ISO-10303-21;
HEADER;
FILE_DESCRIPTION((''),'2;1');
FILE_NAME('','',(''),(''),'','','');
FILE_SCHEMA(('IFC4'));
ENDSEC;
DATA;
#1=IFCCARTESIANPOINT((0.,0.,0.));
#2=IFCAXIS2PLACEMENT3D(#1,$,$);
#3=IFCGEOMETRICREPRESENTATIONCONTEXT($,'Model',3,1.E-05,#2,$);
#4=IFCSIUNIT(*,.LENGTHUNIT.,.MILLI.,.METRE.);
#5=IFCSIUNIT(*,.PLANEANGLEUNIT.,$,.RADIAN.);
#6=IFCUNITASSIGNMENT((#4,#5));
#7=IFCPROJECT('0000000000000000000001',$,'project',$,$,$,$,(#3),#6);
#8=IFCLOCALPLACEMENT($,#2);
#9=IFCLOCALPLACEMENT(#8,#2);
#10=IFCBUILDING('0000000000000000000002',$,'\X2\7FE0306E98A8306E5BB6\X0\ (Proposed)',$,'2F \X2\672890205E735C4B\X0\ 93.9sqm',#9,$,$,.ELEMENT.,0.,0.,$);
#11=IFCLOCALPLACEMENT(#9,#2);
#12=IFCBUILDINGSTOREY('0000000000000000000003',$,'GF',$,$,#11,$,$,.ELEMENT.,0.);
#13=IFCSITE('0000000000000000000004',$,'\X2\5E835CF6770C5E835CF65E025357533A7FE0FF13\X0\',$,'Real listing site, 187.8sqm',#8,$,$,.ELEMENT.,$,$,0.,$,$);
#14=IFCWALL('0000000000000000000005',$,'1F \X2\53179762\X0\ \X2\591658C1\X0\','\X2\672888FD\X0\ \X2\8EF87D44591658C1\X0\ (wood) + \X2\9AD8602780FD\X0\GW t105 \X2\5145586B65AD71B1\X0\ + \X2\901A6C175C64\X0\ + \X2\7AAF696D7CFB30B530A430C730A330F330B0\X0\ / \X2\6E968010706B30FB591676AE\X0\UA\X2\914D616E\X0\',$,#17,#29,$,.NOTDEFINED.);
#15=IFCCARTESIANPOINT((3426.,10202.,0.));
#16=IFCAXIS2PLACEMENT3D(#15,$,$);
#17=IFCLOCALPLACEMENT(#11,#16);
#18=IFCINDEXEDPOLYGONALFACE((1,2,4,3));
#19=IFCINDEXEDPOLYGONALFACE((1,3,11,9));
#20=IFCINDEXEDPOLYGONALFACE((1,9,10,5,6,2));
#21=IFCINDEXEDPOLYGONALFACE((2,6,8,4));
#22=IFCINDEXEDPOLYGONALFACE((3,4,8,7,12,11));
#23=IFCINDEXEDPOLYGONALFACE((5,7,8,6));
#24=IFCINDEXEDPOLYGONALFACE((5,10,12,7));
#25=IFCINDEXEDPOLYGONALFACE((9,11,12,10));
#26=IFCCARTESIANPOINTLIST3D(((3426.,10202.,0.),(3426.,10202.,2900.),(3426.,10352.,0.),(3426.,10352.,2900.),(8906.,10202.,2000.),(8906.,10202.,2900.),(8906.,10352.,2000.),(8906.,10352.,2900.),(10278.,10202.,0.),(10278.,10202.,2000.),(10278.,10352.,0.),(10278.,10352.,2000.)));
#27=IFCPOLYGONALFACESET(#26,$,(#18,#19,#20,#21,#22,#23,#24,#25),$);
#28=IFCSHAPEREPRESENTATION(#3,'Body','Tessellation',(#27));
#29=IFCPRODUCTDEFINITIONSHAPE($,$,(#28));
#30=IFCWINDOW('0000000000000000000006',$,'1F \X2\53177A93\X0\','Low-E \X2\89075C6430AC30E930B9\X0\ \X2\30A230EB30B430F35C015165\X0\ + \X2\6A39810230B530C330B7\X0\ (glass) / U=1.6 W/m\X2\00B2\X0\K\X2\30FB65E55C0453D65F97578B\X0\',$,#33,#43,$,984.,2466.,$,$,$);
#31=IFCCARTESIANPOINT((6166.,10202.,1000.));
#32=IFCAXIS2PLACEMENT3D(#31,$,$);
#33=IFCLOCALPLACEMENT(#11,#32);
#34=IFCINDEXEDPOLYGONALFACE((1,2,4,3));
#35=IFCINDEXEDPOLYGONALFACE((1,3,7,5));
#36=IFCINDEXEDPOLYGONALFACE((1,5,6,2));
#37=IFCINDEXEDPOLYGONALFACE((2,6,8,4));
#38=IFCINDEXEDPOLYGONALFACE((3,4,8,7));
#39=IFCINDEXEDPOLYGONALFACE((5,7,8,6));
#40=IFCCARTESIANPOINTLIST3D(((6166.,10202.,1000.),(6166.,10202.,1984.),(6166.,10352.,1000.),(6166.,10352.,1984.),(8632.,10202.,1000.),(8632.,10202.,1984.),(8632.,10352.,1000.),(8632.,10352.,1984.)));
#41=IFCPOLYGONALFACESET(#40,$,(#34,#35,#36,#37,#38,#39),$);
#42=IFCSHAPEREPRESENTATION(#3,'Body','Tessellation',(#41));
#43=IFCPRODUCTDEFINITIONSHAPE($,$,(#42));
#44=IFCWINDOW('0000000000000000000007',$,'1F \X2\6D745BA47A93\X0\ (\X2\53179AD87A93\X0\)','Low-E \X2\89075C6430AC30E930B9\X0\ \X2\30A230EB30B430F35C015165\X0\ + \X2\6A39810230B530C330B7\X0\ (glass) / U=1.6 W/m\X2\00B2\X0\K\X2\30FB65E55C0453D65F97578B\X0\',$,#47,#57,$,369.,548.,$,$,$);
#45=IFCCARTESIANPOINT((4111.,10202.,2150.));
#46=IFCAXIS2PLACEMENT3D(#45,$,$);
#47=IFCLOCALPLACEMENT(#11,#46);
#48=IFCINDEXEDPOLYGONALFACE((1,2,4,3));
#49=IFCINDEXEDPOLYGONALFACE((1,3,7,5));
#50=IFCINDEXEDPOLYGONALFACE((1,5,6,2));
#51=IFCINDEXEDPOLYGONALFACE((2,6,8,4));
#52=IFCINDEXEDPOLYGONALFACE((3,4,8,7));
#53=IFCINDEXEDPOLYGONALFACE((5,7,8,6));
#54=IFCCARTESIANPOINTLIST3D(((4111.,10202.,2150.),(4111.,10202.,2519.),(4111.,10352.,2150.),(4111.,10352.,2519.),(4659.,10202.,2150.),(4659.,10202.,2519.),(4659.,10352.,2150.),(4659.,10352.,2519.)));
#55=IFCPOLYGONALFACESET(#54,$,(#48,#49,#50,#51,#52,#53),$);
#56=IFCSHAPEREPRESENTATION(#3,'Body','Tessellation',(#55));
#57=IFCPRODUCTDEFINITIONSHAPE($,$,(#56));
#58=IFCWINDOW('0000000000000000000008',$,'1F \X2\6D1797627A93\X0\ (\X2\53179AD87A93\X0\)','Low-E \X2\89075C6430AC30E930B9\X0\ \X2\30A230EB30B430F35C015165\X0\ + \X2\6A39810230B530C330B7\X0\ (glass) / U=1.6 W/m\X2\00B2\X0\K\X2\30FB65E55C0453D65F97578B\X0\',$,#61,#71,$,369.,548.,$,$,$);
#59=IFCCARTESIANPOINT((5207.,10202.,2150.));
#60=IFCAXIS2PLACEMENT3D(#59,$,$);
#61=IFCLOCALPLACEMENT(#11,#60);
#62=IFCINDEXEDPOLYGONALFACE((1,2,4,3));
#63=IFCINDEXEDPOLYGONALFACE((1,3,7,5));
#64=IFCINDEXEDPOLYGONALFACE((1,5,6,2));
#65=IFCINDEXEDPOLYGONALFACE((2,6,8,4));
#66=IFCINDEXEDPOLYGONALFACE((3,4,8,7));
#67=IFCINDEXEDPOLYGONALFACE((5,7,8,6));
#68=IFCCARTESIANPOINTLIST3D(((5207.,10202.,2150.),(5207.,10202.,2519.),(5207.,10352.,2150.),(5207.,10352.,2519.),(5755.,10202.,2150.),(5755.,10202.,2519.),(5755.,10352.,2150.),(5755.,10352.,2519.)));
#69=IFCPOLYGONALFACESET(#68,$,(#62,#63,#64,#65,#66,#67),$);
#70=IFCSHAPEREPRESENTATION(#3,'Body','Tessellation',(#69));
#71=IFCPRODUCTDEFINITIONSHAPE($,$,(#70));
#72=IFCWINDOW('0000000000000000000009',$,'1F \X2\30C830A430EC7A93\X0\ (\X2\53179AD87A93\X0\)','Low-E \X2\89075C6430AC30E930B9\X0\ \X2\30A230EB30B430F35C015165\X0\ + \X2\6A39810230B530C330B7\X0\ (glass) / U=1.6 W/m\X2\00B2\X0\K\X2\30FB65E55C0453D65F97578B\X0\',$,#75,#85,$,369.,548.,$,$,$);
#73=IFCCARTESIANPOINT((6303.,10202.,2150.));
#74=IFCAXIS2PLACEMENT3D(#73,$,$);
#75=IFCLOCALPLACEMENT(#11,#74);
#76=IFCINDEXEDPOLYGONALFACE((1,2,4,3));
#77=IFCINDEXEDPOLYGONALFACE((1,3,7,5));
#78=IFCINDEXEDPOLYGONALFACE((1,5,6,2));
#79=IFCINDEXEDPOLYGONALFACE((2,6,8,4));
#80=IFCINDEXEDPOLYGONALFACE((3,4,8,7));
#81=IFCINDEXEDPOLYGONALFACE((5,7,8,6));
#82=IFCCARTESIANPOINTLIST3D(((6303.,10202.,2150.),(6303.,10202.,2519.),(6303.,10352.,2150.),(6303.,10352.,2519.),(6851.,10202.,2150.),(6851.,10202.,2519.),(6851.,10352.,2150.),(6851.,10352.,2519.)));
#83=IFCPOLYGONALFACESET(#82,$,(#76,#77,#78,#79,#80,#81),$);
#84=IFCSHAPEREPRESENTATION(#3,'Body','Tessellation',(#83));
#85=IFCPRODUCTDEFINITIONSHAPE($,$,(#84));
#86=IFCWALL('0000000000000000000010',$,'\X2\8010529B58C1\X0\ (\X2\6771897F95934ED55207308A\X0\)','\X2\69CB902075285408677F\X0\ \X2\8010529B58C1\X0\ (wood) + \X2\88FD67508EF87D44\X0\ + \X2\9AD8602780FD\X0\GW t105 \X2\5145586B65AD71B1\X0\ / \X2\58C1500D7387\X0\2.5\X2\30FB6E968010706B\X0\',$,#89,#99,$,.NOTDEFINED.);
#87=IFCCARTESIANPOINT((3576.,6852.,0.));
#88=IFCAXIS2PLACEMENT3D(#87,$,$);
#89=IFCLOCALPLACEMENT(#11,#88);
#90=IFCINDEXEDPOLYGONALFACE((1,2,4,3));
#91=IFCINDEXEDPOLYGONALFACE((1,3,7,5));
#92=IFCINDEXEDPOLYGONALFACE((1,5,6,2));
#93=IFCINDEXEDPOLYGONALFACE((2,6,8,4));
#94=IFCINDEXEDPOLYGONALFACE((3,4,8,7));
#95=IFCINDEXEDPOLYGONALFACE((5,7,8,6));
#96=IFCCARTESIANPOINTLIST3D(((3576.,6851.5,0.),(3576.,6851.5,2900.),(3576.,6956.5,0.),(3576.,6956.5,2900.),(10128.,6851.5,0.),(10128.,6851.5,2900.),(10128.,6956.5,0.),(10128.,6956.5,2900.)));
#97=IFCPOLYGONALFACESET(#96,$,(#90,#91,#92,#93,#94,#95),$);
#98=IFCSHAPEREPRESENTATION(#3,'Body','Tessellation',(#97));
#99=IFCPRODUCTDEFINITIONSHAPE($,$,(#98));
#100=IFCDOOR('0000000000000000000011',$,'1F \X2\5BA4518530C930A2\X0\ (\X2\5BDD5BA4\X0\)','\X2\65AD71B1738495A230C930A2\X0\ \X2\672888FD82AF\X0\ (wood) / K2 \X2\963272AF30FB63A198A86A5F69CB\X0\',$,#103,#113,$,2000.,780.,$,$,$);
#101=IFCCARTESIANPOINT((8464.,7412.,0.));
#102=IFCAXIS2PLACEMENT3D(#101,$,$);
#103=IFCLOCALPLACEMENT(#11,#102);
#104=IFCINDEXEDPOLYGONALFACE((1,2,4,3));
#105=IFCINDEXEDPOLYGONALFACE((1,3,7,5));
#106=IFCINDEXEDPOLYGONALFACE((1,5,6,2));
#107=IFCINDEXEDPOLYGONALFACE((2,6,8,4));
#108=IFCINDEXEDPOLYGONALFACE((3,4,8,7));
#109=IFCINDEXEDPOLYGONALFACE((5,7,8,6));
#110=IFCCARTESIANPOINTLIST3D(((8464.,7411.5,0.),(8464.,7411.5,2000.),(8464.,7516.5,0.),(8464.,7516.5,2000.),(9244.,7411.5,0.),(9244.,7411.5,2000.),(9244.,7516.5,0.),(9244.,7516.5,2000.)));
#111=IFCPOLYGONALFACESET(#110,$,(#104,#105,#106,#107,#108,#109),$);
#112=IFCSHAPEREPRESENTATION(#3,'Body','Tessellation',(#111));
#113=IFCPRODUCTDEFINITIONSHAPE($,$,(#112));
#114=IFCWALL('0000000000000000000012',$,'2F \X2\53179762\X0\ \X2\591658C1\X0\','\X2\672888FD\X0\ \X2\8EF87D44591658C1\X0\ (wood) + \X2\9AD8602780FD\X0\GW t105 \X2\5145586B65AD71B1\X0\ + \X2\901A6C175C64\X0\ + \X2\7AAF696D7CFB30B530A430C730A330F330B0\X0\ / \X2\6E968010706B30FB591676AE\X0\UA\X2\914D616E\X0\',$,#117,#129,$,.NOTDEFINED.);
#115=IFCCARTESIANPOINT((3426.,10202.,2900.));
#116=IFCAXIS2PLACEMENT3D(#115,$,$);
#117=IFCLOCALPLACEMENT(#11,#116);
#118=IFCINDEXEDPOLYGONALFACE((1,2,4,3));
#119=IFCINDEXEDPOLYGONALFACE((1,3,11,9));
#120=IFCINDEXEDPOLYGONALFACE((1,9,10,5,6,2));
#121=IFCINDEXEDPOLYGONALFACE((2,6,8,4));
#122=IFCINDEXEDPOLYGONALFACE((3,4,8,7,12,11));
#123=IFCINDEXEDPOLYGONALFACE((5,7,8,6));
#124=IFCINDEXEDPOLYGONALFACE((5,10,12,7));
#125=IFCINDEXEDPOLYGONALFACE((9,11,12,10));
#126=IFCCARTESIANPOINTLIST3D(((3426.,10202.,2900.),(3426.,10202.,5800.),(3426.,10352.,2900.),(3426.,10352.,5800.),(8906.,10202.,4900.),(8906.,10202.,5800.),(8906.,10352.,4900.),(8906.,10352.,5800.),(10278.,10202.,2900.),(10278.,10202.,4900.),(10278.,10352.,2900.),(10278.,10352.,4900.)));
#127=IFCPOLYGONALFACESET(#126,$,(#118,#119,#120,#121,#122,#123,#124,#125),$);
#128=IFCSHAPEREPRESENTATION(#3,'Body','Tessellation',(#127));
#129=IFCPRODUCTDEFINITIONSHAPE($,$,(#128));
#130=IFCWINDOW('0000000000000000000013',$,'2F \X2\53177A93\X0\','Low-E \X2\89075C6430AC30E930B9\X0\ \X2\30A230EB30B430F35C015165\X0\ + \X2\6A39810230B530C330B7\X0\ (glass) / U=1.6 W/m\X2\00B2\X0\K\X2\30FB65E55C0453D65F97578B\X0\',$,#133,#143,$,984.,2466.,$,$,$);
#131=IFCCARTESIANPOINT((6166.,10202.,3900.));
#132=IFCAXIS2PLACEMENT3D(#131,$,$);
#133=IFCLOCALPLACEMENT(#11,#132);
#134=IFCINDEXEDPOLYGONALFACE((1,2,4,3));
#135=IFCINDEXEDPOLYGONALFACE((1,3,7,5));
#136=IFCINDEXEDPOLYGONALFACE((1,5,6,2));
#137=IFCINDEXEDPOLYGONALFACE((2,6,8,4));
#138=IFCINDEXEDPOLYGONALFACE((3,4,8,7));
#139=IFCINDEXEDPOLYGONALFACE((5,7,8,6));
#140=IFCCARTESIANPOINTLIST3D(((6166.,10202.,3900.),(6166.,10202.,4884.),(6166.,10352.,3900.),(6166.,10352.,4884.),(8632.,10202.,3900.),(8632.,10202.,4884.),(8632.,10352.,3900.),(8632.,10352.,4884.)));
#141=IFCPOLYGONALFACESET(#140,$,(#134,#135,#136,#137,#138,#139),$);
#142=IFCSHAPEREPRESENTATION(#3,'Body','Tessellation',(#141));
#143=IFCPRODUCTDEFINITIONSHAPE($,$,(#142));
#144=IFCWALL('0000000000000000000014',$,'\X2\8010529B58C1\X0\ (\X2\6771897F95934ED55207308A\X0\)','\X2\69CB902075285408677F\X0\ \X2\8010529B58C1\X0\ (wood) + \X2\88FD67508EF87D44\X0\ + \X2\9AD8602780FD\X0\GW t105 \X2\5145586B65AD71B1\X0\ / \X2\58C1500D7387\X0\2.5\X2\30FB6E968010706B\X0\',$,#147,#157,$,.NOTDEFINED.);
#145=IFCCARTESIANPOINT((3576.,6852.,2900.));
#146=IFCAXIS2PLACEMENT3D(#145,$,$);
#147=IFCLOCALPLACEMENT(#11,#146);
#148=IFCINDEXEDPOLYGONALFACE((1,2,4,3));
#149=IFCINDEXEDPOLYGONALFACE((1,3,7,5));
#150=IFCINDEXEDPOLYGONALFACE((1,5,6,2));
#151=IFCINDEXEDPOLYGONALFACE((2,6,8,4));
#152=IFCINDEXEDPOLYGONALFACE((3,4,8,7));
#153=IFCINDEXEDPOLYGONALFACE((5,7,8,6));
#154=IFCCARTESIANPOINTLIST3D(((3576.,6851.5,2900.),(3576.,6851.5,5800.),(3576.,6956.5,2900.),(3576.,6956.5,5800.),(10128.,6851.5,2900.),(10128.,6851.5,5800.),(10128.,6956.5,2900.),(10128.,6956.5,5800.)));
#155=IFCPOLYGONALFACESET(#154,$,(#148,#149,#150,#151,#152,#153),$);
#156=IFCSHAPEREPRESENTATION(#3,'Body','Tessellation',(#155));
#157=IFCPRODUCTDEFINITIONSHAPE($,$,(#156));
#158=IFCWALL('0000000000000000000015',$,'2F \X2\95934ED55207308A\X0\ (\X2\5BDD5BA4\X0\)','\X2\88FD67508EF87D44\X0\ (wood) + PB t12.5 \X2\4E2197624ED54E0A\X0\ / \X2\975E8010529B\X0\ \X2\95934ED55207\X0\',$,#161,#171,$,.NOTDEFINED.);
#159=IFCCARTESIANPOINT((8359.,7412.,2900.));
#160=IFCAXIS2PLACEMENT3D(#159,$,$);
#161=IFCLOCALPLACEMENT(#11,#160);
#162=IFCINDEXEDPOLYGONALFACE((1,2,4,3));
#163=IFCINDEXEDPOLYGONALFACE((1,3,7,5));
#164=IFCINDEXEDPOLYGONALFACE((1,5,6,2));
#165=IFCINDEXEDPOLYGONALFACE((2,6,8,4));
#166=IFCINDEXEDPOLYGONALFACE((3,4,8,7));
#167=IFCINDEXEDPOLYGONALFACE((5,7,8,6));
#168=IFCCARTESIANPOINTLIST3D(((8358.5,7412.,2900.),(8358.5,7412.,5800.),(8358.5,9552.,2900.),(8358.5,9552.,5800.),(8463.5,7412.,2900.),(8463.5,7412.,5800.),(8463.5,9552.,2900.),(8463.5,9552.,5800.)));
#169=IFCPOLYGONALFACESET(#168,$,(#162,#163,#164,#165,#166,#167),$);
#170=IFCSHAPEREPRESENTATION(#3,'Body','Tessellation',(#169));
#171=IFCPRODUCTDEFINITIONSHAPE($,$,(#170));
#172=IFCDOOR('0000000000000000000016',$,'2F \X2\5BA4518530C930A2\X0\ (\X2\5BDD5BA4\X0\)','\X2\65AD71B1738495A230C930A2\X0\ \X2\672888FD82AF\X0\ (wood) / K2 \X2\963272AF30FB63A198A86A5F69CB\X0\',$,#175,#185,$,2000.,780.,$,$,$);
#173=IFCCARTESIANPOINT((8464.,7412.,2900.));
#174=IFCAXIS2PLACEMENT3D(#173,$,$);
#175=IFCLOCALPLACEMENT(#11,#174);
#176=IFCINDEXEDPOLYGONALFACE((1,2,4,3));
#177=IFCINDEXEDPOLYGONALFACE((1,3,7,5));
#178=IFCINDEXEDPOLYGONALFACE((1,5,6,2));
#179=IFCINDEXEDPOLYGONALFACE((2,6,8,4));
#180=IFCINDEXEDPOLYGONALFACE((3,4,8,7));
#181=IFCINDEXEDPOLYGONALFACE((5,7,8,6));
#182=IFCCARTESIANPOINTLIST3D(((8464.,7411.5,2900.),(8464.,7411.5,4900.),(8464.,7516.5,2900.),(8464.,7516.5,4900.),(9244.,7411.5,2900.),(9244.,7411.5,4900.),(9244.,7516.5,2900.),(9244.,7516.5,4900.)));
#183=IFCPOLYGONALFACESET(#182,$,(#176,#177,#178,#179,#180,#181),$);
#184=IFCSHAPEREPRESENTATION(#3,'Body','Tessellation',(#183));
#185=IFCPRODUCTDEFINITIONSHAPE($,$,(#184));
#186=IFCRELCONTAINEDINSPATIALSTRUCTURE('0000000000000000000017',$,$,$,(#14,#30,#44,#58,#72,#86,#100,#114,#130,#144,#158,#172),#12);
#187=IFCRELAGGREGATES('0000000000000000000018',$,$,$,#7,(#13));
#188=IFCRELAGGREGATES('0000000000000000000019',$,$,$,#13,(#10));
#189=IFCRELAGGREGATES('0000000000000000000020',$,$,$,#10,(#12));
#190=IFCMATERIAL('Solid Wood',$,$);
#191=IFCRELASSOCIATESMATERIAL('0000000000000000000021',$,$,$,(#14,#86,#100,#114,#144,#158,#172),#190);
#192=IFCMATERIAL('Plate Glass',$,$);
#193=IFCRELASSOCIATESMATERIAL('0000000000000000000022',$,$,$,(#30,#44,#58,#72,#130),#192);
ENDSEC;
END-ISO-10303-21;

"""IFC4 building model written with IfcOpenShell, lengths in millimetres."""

from ifc_helpers import new_model, si_unit, frame, frame_2d, origin, place, context, project, spatial, rectangle, extrude, material, element, fill, save


model = new_model("IFC4")

# Units and contexts
model_context = context("Model", 3, precision=1e-05, world=origin())
ifc_project = project(units=[si_unit("LENGTHUNIT", "METRE", prefix="MILLI"), si_unit("PLANEANGLEUNIT", "RADIAN")], contexts=[model_context])

# Site, building, storey
site_placement = place(None, origin())
site = spatial("IfcSite", under=ifc_project, at=site_placement, Name="広島県広島市南区翠３", ObjectType="Real listing site, 187.8sqm", CompositionType="ELEMENT", RefElevation=0.0)
building_placement = place(site_placement, origin())
building = spatial("IfcBuilding", under=site, at=building_placement, Name="翠の風の家 (Proposed)", ObjectType="2F 木造平屋 93.9sqm", CompositionType="ELEMENT", ElevationOfRefHeight=0.0, ElevationOfTerrain=0.0)
storey_placement = place(building_placement, origin())
storey = spatial("IfcBuildingStorey", under=building, at=storey_placement, Name="GF", CompositionType="ELEMENT", Elevation=0.0)

# Wall, openings, windows
ifc_material_1 = material(Name="Solid Wood")
wall_1_placement = place(storey_placement, frame((3426.0, 10202.0, 0.0)))
wall_1 = element("IfcWall", 1, at=wall_1_placement, inside=storey, material=ifc_material_1, Name="1F 北面 外壁", Description="木製 軸組外壁 (wood) + 高性能GW t105 充填断熱 + 通気層 + 窯業系サイディング / 準耐火・外皮UA配慮", PredefinedType="NOTDEFINED", context=model_context, shape_type="SweptSolid", body=[
    extrude(rectangle(XDim=6852.0, YDim=150.0, at=frame_2d((3426.0, 75.0))), frame((3426.0, 10202.0, 0.0)), (0.0, 0.0, 1.0), 2900.0),
])
opening_1_placement = place(storey_placement, frame((6166.0, 10202.0, 1000.0)))
opening_1 = element("IfcOpeningElement", 2, at=opening_1_placement, cuts=wall_1, PredefinedType="NOTDEFINED", context=model_context, shape_type="SweptSolid", body=[
    extrude(rectangle(XDim=2466.0, YDim=150.0, at=frame_2d((1233.0, 75.0))), frame((6166.0, 10202.0, 1000.0)), (0.0, 0.0, 1.0), 984.0),
])
opening_2_placement = place(storey_placement, frame((4111.0, 10202.0, 2150.0)))
opening_2 = element("IfcOpeningElement", 3, at=opening_2_placement, cuts=wall_1, PredefinedType="NOTDEFINED", context=model_context, shape_type="SweptSolid", body=[
    extrude(rectangle(XDim=548.0, YDim=150.0, at=frame_2d((274.0, 75.0))), frame((4111.0, 10202.0, 2150.0)), (0.0, 0.0, 1.0), 369.0),
])
opening_3_placement = place(storey_placement, frame((5207.0, 10202.0, 2150.0)))
opening_3 = element("IfcOpeningElement", 4, at=opening_3_placement, cuts=wall_1, PredefinedType="NOTDEFINED", context=model_context, shape_type="SweptSolid", body=[
    extrude(rectangle(XDim=548.0, YDim=150.0, at=frame_2d((274.0, 75.0))), frame((5207.0, 10202.0, 2150.0)), (0.0, 0.0, 1.0), 369.0),
])
opening_4_placement = place(storey_placement, frame((6303.0, 10202.0, 2150.0)))
opening_4 = element("IfcOpeningElement", 5, at=opening_4_placement, cuts=wall_1, PredefinedType="NOTDEFINED", context=model_context, shape_type="SweptSolid", body=[
    extrude(rectangle(XDim=548.0, YDim=150.0, at=frame_2d((274.0, 75.0))), frame((6303.0, 10202.0, 2150.0)), (0.0, 0.0, 1.0), 369.0),
])
ifc_material_2 = material(Name="Plate Glass")
window_1_placement = place(storey_placement, frame((6166.0, 10202.0, 1000.0)))
window_1 = element("IfcWindow", 6, at=window_1_placement, inside=storey, material=ifc_material_2, Name="1F 北窓", Description="Low-E 複層ガラス アルゴン封入 + 樹脂サッシ (glass) / U=1.6 W/m²K・日射取得型", OverallHeight=984.0, OverallWidth=2466.0, context=model_context, shape_type="SweptSolid", body=[
    extrude(rectangle(XDim=2466.0, YDim=150.0, at=frame_2d((1233.0, 75.0))), frame((6166.0, 10202.0, 1000.0)), (0.0, 0.0, 1.0), 984.0),
])
fill(opening_1, window_1)
window_2_placement = place(storey_placement, frame((4111.0, 10202.0, 2150.0)))
window_2 = element("IfcWindow", 7, at=window_2_placement, inside=storey, material=ifc_material_2, Name="1F 浴室窓 (北高窓)", Description="Low-E 複層ガラス アルゴン封入 + 樹脂サッシ (glass) / U=1.6 W/m²K・日射取得型", OverallHeight=369.0, OverallWidth=548.0, context=model_context, shape_type="SweptSolid", body=[
    extrude(rectangle(XDim=548.0, YDim=150.0, at=frame_2d((274.0, 75.0))), frame((4111.0, 10202.0, 2150.0)), (0.0, 0.0, 1.0), 369.0),
])
fill(opening_2, window_2)
window_3_placement = place(storey_placement, frame((5207.0, 10202.0, 2150.0)))
window_3 = element("IfcWindow", 8, at=window_3_placement, inside=storey, material=ifc_material_2, Name="1F 洗面窓 (北高窓)", Description="Low-E 複層ガラス アルゴン封入 + 樹脂サッシ (glass) / U=1.6 W/m²K・日射取得型", OverallHeight=369.0, OverallWidth=548.0, context=model_context, shape_type="SweptSolid", body=[
    extrude(rectangle(XDim=548.0, YDim=150.0, at=frame_2d((274.0, 75.0))), frame((5207.0, 10202.0, 2150.0)), (0.0, 0.0, 1.0), 369.0),
])
fill(opening_3, window_3)
window_4_placement = place(storey_placement, frame((6303.0, 10202.0, 2150.0)))
window_4 = element("IfcWindow", 9, at=window_4_placement, inside=storey, material=ifc_material_2, Name="1F トイレ窓 (北高窓)", Description="Low-E 複層ガラス アルゴン封入 + 樹脂サッシ (glass) / U=1.6 W/m²K・日射取得型", OverallHeight=369.0, OverallWidth=548.0, context=model_context, shape_type="SweptSolid", body=[
    extrude(rectangle(XDim=548.0, YDim=150.0, at=frame_2d((274.0, 75.0))), frame((6303.0, 10202.0, 2150.0)), (0.0, 0.0, 1.0), 369.0),
])
fill(opening_4, window_4)

# Wall
wall_2_placement = place(storey_placement, frame((3576.0, 6852.0, 0.0)))
element("IfcWall", 10, at=wall_2_placement, inside=storey, material=ifc_material_1, Name="耐力壁 (東西間仕切り)", Description="構造用合板 耐力壁 (wood) + 製材軸組 + 高性能GW t105 充填断熱 / 壁倍率2.5・準耐火", PredefinedType="NOTDEFINED", context=model_context, shape_type="SweptSolid", body=[
    extrude(rectangle(XDim=6552.0, YDim=105.0, at=frame_2d((3276.0, 52.0))), frame((3576.0, 6852.0, 0.0)), (0.0, 0.0, 1.0), 2900.0),
])

# Door
door_1_placement = place(storey_placement, frame((8464.0, 7412.0, 0.0)))
element("IfcDoor", 11, at=door_1_placement, inside=storey, material=ifc_material_1, Name="1F 室内ドア (寝室)", Description="断熱玄関ドア 木製芯 (wood) / K2 防犯・採風機構", OverallHeight=2000.0, OverallWidth=780.0, context=model_context, shape_type="SweptSolid", body=[
    extrude(rectangle(XDim=780.0, YDim=105.0, at=frame_2d((390.0, 52.0))), frame((8464.0, 7412.0, 0.0)), (0.0, 0.0, 1.0), 2000.0),
])

# Wall, opening, window
wall_3_placement = place(storey_placement, frame((3426.0, 10202.0, 2900.0)))
wall_3 = element("IfcWall", 12, at=wall_3_placement, inside=storey, material=ifc_material_1, Name="2F 北面 外壁", Description="木製 軸組外壁 (wood) + 高性能GW t105 充填断熱 + 通気層 + 窯業系サイディング / 準耐火・外皮UA配慮", PredefinedType="NOTDEFINED", context=model_context, shape_type="SweptSolid", body=[
    extrude(rectangle(XDim=6852.0, YDim=150.0, at=frame_2d((3426.0, 75.0))), frame((3426.0, 10202.0, 2900.0)), (0.0, 0.0, 1.0), 2900.0),
])
opening_5_placement = place(storey_placement, frame((6166.0, 10202.0, 3900.0)))
opening_5 = element("IfcOpeningElement", 13, at=opening_5_placement, cuts=wall_3, PredefinedType="NOTDEFINED", context=model_context, shape_type="SweptSolid", body=[
    extrude(rectangle(XDim=2466.0, YDim=150.0, at=frame_2d((1233.0, 75.0))), frame((6166.0, 10202.0, 3900.0)), (0.0, 0.0, 1.0), 984.0),
])
window_5_placement = place(storey_placement, frame((6166.0, 10202.0, 3900.0)))
window_5 = element("IfcWindow", 14, at=window_5_placement, inside=storey, material=ifc_material_2, Name="2F 北窓", Description="Low-E 複層ガラス アルゴン封入 + 樹脂サッシ (glass) / U=1.6 W/m²K・日射取得型", OverallHeight=984.0, OverallWidth=2466.0, context=model_context, shape_type="SweptSolid", body=[
    extrude(rectangle(XDim=2466.0, YDim=150.0, at=frame_2d((1233.0, 75.0))), frame((6166.0, 10202.0, 3900.0)), (0.0, 0.0, 1.0), 984.0),
])
fill(opening_5, window_5)

# Walls
wall_4_placement = place(storey_placement, frame((3576.0, 6852.0, 2900.0)))
element("IfcWall", 15, at=wall_4_placement, inside=storey, material=ifc_material_1, Name="耐力壁 (東西間仕切り)", Description="構造用合板 耐力壁 (wood) + 製材軸組 + 高性能GW t105 充填断熱 / 壁倍率2.5・準耐火", PredefinedType="NOTDEFINED", context=model_context, shape_type="SweptSolid", body=[
    extrude(rectangle(XDim=6552.0, YDim=105.0, at=frame_2d((3276.0, 52.0))), frame((3576.0, 6852.0, 2900.0)), (0.0, 0.0, 1.0), 2900.0),
])
wall_5_placement = place(storey_placement, frame((8359.0, 7412.0, 2900.0)))
element("IfcWall", 16, at=wall_5_placement, inside=storey, material=ifc_material_1, Name="2F 間仕切り (寝室)", Description="製材軸組 (wood) + PB t12.5 両面仕上 / 非耐力 間仕切", PredefinedType="NOTDEFINED", context=model_context, shape_type="SweptSolid", body=[
    extrude(rectangle(XDim=105.0, YDim=2140.0, at=frame_2d((52.0, 1070.0))), frame((8359.0, 7412.0, 2900.0)), (0.0, 0.0, 1.0), 2900.0),
])

# Door
door_2_placement = place(storey_placement, frame((8464.0, 7412.0, 2900.0)))
element("IfcDoor", 17, at=door_2_placement, inside=storey, material=ifc_material_1, Name="2F 室内ドア (寝室)", Description="断熱玄関ドア 木製芯 (wood) / K2 防犯・採風機構", OverallHeight=2000.0, OverallWidth=780.0, context=model_context, shape_type="SweptSolid", body=[
    extrude(rectangle(XDim=780.0, YDim=105.0, at=frame_2d((390.0, 52.0))), frame((8464.0, 7412.0, 2900.0)), (0.0, 0.0, 1.0), 2000.0),
])

save(model, "model.ifc")
